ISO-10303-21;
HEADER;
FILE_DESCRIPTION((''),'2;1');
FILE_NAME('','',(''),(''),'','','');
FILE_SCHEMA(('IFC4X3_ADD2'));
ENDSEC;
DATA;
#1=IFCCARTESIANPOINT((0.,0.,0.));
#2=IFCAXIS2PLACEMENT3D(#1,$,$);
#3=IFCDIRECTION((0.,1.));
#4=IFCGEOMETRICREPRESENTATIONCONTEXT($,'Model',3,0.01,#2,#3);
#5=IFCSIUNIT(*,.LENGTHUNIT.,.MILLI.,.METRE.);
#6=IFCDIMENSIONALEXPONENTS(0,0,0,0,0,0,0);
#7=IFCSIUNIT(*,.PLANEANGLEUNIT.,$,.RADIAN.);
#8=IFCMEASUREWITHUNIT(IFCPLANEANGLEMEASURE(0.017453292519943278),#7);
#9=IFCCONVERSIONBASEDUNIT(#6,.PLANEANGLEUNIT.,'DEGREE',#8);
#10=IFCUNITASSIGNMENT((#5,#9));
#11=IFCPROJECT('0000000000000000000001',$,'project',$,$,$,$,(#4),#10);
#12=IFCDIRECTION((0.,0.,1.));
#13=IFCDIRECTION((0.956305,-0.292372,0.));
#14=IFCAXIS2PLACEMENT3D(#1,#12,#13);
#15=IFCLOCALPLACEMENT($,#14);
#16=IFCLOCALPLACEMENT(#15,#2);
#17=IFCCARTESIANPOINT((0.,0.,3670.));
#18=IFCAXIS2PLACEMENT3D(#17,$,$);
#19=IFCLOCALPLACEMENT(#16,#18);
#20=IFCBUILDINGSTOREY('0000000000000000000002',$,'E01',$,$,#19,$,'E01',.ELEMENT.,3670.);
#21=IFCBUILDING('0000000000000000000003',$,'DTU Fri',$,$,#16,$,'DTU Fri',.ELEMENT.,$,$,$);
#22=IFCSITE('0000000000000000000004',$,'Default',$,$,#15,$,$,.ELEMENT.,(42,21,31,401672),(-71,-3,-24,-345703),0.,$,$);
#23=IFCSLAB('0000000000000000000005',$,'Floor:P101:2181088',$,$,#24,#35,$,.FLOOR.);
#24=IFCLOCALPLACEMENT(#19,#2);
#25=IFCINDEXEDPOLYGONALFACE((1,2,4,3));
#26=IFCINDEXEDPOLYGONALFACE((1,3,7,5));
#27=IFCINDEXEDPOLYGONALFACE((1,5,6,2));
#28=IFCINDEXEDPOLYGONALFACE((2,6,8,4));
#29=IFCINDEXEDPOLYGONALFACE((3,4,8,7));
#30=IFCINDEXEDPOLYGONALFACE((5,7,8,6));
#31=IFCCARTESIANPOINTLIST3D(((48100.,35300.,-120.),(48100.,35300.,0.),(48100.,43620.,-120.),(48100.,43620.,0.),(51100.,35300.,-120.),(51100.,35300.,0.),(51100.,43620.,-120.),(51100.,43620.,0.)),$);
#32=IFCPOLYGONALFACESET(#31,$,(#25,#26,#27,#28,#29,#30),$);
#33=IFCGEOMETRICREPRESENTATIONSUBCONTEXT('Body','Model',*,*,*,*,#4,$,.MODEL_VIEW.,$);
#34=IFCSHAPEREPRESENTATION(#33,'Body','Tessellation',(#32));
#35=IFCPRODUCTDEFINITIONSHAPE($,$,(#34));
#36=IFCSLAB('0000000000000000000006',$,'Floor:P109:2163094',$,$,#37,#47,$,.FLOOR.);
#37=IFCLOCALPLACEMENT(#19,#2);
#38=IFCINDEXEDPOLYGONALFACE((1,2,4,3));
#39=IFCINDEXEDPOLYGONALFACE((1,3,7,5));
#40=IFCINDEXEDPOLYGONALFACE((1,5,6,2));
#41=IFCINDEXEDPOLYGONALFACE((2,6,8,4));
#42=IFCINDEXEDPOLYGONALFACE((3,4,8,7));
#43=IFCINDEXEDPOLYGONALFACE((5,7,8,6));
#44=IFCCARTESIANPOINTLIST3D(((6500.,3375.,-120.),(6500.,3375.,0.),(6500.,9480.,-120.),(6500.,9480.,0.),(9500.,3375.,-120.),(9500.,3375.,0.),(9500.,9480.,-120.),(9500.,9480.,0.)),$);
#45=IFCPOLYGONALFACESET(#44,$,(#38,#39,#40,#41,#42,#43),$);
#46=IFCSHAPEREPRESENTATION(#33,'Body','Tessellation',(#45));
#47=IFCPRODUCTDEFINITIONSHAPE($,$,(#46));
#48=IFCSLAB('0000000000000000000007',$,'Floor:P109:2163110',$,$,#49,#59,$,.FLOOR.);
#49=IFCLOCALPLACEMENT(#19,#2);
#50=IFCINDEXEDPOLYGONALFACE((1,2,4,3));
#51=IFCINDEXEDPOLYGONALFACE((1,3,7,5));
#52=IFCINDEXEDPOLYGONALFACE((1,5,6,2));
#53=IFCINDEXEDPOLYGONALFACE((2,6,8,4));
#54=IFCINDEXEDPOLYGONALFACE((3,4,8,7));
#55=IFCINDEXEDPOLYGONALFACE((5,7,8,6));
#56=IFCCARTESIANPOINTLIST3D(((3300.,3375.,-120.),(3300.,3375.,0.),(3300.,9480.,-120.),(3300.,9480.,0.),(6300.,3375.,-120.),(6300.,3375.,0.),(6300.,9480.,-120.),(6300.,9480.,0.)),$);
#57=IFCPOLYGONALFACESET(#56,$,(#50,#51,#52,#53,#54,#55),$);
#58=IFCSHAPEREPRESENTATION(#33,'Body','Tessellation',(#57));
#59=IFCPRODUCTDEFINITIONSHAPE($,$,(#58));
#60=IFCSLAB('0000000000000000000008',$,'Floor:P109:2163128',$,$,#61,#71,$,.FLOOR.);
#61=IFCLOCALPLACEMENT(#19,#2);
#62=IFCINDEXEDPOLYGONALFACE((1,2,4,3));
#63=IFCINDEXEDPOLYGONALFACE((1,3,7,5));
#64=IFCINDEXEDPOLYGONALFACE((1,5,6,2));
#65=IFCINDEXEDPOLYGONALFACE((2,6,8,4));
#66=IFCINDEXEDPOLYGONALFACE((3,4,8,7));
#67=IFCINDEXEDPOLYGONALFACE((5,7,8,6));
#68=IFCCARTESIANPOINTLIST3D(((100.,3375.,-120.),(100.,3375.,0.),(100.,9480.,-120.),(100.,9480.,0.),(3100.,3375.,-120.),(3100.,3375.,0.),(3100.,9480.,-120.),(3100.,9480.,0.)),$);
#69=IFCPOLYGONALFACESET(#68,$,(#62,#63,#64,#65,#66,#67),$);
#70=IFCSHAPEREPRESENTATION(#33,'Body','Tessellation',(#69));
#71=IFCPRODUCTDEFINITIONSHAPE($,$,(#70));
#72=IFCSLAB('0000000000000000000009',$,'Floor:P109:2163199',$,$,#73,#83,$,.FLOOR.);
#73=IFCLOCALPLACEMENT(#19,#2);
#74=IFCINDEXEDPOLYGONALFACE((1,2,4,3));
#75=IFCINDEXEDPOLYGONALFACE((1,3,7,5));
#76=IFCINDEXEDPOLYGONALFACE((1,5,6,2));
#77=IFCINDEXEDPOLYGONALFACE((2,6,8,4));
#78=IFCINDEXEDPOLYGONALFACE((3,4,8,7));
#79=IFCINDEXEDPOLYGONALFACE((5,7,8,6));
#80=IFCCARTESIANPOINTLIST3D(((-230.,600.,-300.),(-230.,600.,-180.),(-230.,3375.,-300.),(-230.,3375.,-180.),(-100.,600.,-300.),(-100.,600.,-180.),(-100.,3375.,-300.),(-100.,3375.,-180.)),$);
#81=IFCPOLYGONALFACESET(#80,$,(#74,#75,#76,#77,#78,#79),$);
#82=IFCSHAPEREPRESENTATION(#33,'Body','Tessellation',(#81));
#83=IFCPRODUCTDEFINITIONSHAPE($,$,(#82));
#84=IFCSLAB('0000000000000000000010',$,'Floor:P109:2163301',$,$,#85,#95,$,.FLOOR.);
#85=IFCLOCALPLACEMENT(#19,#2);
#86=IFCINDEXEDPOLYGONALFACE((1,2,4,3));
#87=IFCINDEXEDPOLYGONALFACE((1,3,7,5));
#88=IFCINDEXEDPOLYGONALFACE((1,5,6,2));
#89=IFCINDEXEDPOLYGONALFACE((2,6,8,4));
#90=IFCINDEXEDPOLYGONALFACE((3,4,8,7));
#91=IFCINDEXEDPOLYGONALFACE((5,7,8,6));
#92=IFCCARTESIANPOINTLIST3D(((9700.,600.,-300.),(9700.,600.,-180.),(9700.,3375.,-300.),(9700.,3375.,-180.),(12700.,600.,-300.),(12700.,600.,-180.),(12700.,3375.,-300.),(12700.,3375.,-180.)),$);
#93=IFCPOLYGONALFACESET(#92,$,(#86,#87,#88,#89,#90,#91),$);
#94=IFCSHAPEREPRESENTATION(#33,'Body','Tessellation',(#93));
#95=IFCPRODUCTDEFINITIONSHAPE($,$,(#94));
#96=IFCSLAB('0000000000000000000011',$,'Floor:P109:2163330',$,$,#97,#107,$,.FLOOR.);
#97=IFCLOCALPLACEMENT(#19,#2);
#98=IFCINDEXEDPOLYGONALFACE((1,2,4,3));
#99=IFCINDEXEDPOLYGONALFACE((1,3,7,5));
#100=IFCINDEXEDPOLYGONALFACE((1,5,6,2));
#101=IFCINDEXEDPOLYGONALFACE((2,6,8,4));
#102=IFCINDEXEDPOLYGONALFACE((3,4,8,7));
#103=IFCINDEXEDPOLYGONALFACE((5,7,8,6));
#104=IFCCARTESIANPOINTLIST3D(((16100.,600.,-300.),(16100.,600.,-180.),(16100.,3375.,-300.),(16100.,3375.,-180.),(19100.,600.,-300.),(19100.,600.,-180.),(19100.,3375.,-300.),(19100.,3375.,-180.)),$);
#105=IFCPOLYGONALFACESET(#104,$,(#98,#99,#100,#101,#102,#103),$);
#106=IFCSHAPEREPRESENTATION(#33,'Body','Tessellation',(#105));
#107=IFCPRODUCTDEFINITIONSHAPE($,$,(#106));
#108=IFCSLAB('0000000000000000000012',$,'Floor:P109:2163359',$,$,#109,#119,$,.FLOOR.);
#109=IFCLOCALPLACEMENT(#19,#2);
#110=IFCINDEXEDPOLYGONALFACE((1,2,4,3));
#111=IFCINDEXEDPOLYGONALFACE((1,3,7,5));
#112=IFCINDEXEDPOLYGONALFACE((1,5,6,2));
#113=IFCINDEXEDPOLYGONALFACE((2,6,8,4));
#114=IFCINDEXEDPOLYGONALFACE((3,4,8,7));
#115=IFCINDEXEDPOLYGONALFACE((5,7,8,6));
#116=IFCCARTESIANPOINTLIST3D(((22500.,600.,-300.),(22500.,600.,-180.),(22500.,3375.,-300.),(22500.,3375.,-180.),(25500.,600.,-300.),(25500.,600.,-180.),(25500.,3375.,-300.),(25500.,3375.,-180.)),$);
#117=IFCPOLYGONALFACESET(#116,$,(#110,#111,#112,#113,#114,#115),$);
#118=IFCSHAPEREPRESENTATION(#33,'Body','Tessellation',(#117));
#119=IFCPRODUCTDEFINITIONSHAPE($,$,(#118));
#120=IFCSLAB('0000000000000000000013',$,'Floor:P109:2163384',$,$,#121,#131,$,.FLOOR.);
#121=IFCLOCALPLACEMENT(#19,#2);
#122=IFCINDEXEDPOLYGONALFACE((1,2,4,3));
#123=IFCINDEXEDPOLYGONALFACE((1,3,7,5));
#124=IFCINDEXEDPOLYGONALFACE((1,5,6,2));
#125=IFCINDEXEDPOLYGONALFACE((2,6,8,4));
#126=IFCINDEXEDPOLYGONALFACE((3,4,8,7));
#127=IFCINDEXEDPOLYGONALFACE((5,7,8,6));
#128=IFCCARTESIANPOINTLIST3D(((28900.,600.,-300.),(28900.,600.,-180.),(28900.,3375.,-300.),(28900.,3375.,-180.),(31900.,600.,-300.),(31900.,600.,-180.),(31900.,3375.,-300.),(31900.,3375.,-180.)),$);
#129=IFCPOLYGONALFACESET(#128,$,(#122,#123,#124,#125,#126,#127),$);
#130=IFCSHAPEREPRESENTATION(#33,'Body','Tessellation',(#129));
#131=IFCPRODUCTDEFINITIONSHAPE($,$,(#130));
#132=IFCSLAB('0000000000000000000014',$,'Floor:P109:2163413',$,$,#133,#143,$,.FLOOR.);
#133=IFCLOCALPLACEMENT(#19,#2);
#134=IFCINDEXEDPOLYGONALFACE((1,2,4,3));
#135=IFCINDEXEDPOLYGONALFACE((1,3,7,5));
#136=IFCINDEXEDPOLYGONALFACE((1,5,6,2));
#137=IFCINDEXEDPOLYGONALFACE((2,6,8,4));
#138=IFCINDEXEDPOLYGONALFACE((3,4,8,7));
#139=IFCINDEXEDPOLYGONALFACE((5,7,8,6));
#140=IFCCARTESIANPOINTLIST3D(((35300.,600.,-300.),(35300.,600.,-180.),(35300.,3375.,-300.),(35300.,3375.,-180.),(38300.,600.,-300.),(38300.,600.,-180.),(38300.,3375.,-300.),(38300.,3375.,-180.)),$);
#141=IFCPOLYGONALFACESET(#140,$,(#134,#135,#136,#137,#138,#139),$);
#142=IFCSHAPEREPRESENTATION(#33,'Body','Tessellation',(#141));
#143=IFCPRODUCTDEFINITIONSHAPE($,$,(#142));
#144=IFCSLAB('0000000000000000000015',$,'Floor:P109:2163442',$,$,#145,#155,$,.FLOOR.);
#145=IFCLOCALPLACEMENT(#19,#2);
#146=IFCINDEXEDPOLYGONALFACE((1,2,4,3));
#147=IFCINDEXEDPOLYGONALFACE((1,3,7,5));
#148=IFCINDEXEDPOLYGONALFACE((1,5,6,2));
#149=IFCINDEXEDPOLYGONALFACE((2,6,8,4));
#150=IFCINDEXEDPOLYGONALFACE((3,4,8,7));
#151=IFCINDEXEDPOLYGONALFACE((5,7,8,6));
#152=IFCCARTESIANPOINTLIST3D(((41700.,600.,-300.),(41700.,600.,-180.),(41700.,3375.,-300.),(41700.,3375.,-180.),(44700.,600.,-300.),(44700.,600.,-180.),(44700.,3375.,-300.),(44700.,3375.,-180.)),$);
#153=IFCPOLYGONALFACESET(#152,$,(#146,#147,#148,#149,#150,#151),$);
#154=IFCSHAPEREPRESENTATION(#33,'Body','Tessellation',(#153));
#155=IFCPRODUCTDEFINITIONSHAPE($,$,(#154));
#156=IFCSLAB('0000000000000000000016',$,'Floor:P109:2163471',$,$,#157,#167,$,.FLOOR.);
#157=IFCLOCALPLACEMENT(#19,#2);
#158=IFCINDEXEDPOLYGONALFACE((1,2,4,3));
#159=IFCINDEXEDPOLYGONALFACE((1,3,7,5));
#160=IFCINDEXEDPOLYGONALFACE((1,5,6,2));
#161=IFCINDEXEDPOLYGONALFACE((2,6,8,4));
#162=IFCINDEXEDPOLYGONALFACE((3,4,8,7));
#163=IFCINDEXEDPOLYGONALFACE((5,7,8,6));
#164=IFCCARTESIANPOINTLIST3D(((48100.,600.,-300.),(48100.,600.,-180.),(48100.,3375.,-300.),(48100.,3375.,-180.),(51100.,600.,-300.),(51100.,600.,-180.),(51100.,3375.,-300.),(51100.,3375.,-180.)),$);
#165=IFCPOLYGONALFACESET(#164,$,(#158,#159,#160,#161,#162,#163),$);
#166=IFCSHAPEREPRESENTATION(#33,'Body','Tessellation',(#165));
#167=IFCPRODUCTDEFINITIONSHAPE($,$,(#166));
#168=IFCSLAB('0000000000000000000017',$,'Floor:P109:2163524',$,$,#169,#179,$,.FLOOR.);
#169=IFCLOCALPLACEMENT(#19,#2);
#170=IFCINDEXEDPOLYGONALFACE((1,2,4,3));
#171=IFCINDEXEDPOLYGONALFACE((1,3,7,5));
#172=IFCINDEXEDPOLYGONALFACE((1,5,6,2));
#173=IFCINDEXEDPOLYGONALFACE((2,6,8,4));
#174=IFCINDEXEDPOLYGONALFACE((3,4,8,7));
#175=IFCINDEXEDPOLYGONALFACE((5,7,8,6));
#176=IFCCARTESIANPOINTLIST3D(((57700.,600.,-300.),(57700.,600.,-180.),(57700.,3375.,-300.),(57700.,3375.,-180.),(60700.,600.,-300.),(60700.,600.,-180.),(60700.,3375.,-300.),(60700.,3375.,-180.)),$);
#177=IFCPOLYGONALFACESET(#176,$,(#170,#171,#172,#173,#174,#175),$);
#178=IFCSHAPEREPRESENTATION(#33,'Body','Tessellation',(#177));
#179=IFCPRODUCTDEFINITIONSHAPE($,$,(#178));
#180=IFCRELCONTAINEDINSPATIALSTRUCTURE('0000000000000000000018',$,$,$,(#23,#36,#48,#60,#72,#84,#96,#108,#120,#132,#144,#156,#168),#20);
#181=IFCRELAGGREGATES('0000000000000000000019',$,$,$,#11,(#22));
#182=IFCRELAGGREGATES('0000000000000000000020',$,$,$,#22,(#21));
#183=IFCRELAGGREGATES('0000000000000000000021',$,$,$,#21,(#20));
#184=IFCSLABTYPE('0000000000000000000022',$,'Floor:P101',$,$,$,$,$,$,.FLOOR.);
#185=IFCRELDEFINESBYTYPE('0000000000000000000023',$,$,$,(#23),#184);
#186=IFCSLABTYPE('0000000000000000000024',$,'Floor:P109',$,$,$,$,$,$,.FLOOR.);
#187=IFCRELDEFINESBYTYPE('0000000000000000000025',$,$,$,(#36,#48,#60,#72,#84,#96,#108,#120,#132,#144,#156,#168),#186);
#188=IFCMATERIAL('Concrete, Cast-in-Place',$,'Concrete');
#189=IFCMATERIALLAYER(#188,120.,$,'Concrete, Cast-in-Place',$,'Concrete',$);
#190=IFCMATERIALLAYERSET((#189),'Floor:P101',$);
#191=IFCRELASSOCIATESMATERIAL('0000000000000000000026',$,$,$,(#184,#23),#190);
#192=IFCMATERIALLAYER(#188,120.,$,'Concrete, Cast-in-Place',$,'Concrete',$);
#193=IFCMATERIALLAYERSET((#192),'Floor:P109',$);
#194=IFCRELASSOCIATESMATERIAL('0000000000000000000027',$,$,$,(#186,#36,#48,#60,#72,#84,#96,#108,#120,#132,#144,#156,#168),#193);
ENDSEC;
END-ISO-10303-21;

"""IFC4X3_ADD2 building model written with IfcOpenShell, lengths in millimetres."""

from ifc_helpers import new_model, entity, si_unit, converted_unit, direction, frame, frame_2d, origin, place, context, subcontext, project, spatial, rectangle, extrude, material, layer, layer_set, layer_usage, type_object, element, save


model = new_model("IFC4X3_ADD2")

# Units and contexts
model_context = context("Model", 3, precision=0.01, world=origin(), true_north=direction((0.0, 1.0)))
body_context = subcontext(model_context, "Body", "Model", "MODEL_VIEW")
ifc_project = project(units=[si_unit("LENGTHUNIT", "METRE", prefix="MILLI"), converted_unit("PLANEANGLEUNIT", "DEGREE", entity("IfcPlaneAngleMeasure", 0.017453292519943278), si_unit("PLANEANGLEUNIT", "RADIAN"), dimensions=[0, 0, 0, 0, 0, 0, 0])], contexts=[model_context])

# Site, building, storey
site_placement = place(None, frame((0.0, 0.0, 0.0), z_axis=(0.0, 0.0, 1.0), x_axis=(0.956305, -0.292372, 0.0)))
site = spatial("IfcSite", under=ifc_project, at=site_placement, Name="Default", CompositionType="ELEMENT", RefLatitude=(42, 21, 31, 401672), RefLongitude=(-71, -3, -24, -345703), RefElevation=0.0)
building_placement = place(site_placement, origin())
building = spatial("IfcBuilding", under=site, at=building_placement, Name="DTU Fri", LongName="DTU Fri", CompositionType="ELEMENT")
storey_placement = place(building_placement, frame((0.0, 0.0, 3670.0)))
storey = spatial("IfcBuildingStorey", under=building, at=storey_placement, Name="E01", LongName="E01", CompositionType="ELEMENT", Elevation=3670.0)

# Slabs
ifc_material = material(Name="Concrete, Cast-in-Place", Category="Concrete")
ifc_layer_1 = layer(ifc_material, 120.0, Name="Concrete, Cast-in-Place", Category="Concrete")
ifc_layer_set_1 = layer_set([ifc_layer_1], Name="Floor:P101")
ifc_layer_usage_1 = layer_usage(ifc_layer_set_1, "AXIS3", "POSITIVE", 0.0)
slab_type_1 = type_object("IfcSlabType", Name="Floor:P101", PredefinedType="FLOOR", material=ifc_layer_set_1)
slab_1_placement = place(storey_placement, origin())
element("IfcSlab", 1, at=slab_1_placement, inside=storey, type_object=slab_type_1, material=ifc_layer_usage_1, Name="Floor:P101:2181088", PredefinedType="FLOOR", context=body_context, shape_type="SweptSolid", body=[
    extrude(rectangle(XDim=8320.0, YDim=3000.0, at=frame_2d((0.0, 0.0), x_axis=(1.0, 0.0))), frame((49600.0, 39460.0, 0.0), z_axis=(0.0, 0.0, -1.0), x_axis=(0.0, 1.0, 0.0)), (0.0, 0.0, 1.0), 120.0),
])
ifc_layer_2 = layer(ifc_material, 120.0, Name="Concrete, Cast-in-Place", Category="Concrete")
ifc_layer_set_2 = layer_set([ifc_layer_2], Name="Floor:P109")
ifc_layer_usage_2 = layer_usage(ifc_layer_set_2, "AXIS3", "POSITIVE", 0.0)
slab_type_2 = type_object("IfcSlabType", Name="Floor:P109", PredefinedType="FLOOR", material=ifc_layer_set_2)
slab_2_placement = place(storey_placement, origin())
element("IfcSlab", 2, at=slab_2_placement, inside=storey, type_object=slab_type_2, material=ifc_layer_usage_2, Name="Floor:P109:2163094", PredefinedType="FLOOR", context=body_context, shape_type="SweptSolid", body=[
    extrude(rectangle(XDim=6105.0, YDim=3000.0, at=frame_2d((0.0, 0.0), x_axis=(1.0, 0.0))), frame((8000.0, 6427.5, 0.0), z_axis=(0.0, 0.0, -1.0), x_axis=(0.0, 1.0, 0.0)), (0.0, 0.0, 1.0), 120.0),
])
ifc_layer_usage_3 = layer_usage(ifc_layer_set_2, "AXIS3", "POSITIVE", 0.0)
slab_3_placement = place(storey_placement, origin())
element("IfcSlab", 3, at=slab_3_placement, inside=storey, type_object=slab_type_2, material=ifc_layer_usage_3, Name="Floor:P109:2163110", PredefinedType="FLOOR", context=body_context, shape_type="SweptSolid", body=[
    extrude(rectangle(XDim=6105.0, YDim=3000.0, at=frame_2d((0.0, 0.0), x_axis=(1.0, 0.0))), frame((4800.0, 6427.5, 0.0), z_axis=(0.0, 0.0, -1.0), x_axis=(0.0, 1.0, 0.0)), (0.0, 0.0, 1.0), 120.0),
])
ifc_layer_usage_4 = layer_usage(ifc_layer_set_2, "AXIS3", "POSITIVE", 0.0)
slab_4_placement = place(storey_placement, origin())
element("IfcSlab", 4, at=slab_4_placement, inside=storey, type_object=slab_type_2, material=ifc_layer_usage_4, Name="Floor:P109:2163128", PredefinedType="FLOOR", context=body_context, shape_type="SweptSolid", body=[
    extrude(rectangle(XDim=6105.0, YDim=3000.0, at=frame_2d((0.0, 0.0), x_axis=(1.0, 0.0))), frame((1600.0, 6427.5, 0.0), z_axis=(0.0, 0.0, -1.0), x_axis=(0.0, 1.0, 0.0)), (0.0, 0.0, 1.0), 120.0),
])
ifc_layer_usage_5 = layer_usage(ifc_layer_set_2, "AXIS3", "POSITIVE", 0.0)
slab_5_placement = place(storey_placement, origin())
element("IfcSlab", 5, at=slab_5_placement, inside=storey, type_object=slab_type_2, material=ifc_layer_usage_5, Name="Floor:P109:2163199", PredefinedType="FLOOR", context=body_context, shape_type="SweptSolid", body=[
    extrude(rectangle(XDim=2775.0, YDim=130.0, at=frame_2d((0.0, 0.0), x_axis=(1.0, 0.0))), frame((-165.0, 1987.5, -180.0), z_axis=(0.0, 0.0, -1.0), x_axis=(0.0, 1.0, 0.0)), (0.0, 0.0, 1.0), 120.0),
])
ifc_layer_usage_6 = layer_usage(ifc_layer_set_2, "AXIS3", "POSITIVE", 0.0)
slab_6_placement = place(storey_placement, origin())
element("IfcSlab", 6, at=slab_6_placement, inside=storey, type_object=slab_type_2, material=ifc_layer_usage_6, Name="Floor:P109:2163301", PredefinedType="FLOOR", context=body_context, shape_type="SweptSolid", body=[
    extrude(rectangle(XDim=2775.0, YDim=3000.0, at=frame_2d((0.0, 0.0), x_axis=(1.0, 0.0))), frame((11200.0, 1987.5, -180.0), z_axis=(0.0, 0.0, -1.0), x_axis=(0.0, 1.0, 0.0)), (0.0, 0.0, 1.0), 120.0),
])
ifc_layer_usage_7 = layer_usage(ifc_layer_set_2, "AXIS3", "POSITIVE", 0.0)
slab_7_placement = place(storey_placement, origin())
element("IfcSlab", 7, at=slab_7_placement, inside=storey, type_object=slab_type_2, material=ifc_layer_usage_7, Name="Floor:P109:2163330", PredefinedType="FLOOR", context=body_context, shape_type="SweptSolid", body=[
    extrude(rectangle(XDim=2775.0, YDim=3000.0, at=frame_2d((0.0, 0.0), x_axis=(1.0, 0.0))), frame((17600.0, 1987.5, -180.0), z_axis=(0.0, 0.0, -1.0), x_axis=(0.0, 1.0, 0.0)), (0.0, 0.0, 1.0), 120.0),
])
ifc_layer_usage_8 = layer_usage(ifc_layer_set_2, "AXIS3", "POSITIVE", 0.0)
slab_8_placement = place(storey_placement, origin())
element("IfcSlab", 8, at=slab_8_placement, inside=storey, type_object=slab_type_2, material=ifc_layer_usage_8, Name="Floor:P109:2163359", PredefinedType="FLOOR", context=body_context, shape_type="SweptSolid", body=[
    extrude(rectangle(XDim=2775.0, YDim=3000.0, at=frame_2d((0.0, 0.0), x_axis=(1.0, 0.0))), frame((24000.0, 1987.5, -180.0), z_axis=(0.0, 0.0, -1.0), x_axis=(0.0, 1.0, 0.0)), (0.0, 0.0, 1.0), 120.0),
])
ifc_layer_usage_9 = layer_usage(ifc_layer_set_2, "AXIS3", "POSITIVE", 0.0)
slab_9_placement = place(storey_placement, origin())
element("IfcSlab", 9, at=slab_9_placement, inside=storey, type_object=slab_type_2, material=ifc_layer_usage_9, Name="Floor:P109:2163384", PredefinedType="FLOOR", context=body_context, shape_type="SweptSolid", body=[
    extrude(rectangle(XDim=2775.0, YDim=3000.0, at=frame_2d((0.0, 0.0), x_axis=(1.0, 0.0))), frame((30400.0, 1987.5, -180.0), z_axis=(0.0, 0.0, -1.0), x_axis=(0.0, 1.0, 0.0)), (0.0, 0.0, 1.0), 120.0),
])
ifc_layer_usage_10 = layer_usage(ifc_layer_set_2, "AXIS3", "POSITIVE", 0.0)
slab_10_placement = place(storey_placement, origin())
element("IfcSlab", 10, at=slab_10_placement, inside=storey, type_object=slab_type_2, material=ifc_layer_usage_10, Name="Floor:P109:2163413", PredefinedType="FLOOR", context=body_context, shape_type="SweptSolid", body=[
    extrude(rectangle(XDim=2775.0, YDim=3000.0, at=frame_2d((0.0, 0.0), x_axis=(1.0, 0.0))), frame((36800.0, 1987.5, -180.0), z_axis=(0.0, 0.0, -1.0), x_axis=(0.0, 1.0, 0.0)), (0.0, 0.0, 1.0), 120.0),
])
ifc_layer_usage_11 = layer_usage(ifc_layer_set_2, "AXIS3", "POSITIVE", 0.0)
slab_11_placement = place(storey_placement, origin())
element("IfcSlab", 11, at=slab_11_placement, inside=storey, type_object=slab_type_2, material=ifc_layer_usage_11, Name="Floor:P109:2163442", PredefinedType="FLOOR", context=body_context, shape_type="SweptSolid", body=[
    extrude(rectangle(XDim=2775.0, YDim=3000.0, at=frame_2d((0.0, 0.0), x_axis=(1.0, 0.0))), frame((43200.0, 1987.5, -180.0), z_axis=(0.0, 0.0, -1.0), x_axis=(0.0, 1.0, 0.0)), (0.0, 0.0, 1.0), 120.0),
])
ifc_layer_usage_12 = layer_usage(ifc_layer_set_2, "AXIS3", "POSITIVE", 0.0)
slab_12_placement = place(storey_placement, origin())
element("IfcSlab", 12, at=slab_12_placement, inside=storey, type_object=slab_type_2, material=ifc_layer_usage_12, Name="Floor:P109:2163471", PredefinedType="FLOOR", context=body_context, shape_type="SweptSolid", body=[
    extrude(rectangle(XDim=2775.0, YDim=3000.0, at=frame_2d((0.0, 0.0), x_axis=(1.0, 0.0))), frame((49600.0, 1987.5, -180.0), z_axis=(0.0, 0.0, -1.0), x_axis=(0.0, 1.0, 0.0)), (0.0, 0.0, 1.0), 120.0),
])
ifc_layer_usage_13 = layer_usage(ifc_layer_set_2, "AXIS3", "POSITIVE", 0.0)
slab_13_placement = place(storey_placement, origin())
element("IfcSlab", 13, at=slab_13_placement, inside=storey, type_object=slab_type_2, material=ifc_layer_usage_13, Name="Floor:P109:2163524", PredefinedType="FLOOR", context=body_context, shape_type="SweptSolid", body=[
    extrude(rectangle(XDim=2775.0, YDim=3000.0, at=frame_2d((0.0, 0.0), x_axis=(1.0, 0.0))), frame((59200.0, 1987.5, -180.0), z_axis=(0.0, 0.0, -1.0), x_axis=(0.0, 1.0, 0.0)), (0.0, 0.0, 1.0), 120.0),
])

save(model, "model.ifc")
